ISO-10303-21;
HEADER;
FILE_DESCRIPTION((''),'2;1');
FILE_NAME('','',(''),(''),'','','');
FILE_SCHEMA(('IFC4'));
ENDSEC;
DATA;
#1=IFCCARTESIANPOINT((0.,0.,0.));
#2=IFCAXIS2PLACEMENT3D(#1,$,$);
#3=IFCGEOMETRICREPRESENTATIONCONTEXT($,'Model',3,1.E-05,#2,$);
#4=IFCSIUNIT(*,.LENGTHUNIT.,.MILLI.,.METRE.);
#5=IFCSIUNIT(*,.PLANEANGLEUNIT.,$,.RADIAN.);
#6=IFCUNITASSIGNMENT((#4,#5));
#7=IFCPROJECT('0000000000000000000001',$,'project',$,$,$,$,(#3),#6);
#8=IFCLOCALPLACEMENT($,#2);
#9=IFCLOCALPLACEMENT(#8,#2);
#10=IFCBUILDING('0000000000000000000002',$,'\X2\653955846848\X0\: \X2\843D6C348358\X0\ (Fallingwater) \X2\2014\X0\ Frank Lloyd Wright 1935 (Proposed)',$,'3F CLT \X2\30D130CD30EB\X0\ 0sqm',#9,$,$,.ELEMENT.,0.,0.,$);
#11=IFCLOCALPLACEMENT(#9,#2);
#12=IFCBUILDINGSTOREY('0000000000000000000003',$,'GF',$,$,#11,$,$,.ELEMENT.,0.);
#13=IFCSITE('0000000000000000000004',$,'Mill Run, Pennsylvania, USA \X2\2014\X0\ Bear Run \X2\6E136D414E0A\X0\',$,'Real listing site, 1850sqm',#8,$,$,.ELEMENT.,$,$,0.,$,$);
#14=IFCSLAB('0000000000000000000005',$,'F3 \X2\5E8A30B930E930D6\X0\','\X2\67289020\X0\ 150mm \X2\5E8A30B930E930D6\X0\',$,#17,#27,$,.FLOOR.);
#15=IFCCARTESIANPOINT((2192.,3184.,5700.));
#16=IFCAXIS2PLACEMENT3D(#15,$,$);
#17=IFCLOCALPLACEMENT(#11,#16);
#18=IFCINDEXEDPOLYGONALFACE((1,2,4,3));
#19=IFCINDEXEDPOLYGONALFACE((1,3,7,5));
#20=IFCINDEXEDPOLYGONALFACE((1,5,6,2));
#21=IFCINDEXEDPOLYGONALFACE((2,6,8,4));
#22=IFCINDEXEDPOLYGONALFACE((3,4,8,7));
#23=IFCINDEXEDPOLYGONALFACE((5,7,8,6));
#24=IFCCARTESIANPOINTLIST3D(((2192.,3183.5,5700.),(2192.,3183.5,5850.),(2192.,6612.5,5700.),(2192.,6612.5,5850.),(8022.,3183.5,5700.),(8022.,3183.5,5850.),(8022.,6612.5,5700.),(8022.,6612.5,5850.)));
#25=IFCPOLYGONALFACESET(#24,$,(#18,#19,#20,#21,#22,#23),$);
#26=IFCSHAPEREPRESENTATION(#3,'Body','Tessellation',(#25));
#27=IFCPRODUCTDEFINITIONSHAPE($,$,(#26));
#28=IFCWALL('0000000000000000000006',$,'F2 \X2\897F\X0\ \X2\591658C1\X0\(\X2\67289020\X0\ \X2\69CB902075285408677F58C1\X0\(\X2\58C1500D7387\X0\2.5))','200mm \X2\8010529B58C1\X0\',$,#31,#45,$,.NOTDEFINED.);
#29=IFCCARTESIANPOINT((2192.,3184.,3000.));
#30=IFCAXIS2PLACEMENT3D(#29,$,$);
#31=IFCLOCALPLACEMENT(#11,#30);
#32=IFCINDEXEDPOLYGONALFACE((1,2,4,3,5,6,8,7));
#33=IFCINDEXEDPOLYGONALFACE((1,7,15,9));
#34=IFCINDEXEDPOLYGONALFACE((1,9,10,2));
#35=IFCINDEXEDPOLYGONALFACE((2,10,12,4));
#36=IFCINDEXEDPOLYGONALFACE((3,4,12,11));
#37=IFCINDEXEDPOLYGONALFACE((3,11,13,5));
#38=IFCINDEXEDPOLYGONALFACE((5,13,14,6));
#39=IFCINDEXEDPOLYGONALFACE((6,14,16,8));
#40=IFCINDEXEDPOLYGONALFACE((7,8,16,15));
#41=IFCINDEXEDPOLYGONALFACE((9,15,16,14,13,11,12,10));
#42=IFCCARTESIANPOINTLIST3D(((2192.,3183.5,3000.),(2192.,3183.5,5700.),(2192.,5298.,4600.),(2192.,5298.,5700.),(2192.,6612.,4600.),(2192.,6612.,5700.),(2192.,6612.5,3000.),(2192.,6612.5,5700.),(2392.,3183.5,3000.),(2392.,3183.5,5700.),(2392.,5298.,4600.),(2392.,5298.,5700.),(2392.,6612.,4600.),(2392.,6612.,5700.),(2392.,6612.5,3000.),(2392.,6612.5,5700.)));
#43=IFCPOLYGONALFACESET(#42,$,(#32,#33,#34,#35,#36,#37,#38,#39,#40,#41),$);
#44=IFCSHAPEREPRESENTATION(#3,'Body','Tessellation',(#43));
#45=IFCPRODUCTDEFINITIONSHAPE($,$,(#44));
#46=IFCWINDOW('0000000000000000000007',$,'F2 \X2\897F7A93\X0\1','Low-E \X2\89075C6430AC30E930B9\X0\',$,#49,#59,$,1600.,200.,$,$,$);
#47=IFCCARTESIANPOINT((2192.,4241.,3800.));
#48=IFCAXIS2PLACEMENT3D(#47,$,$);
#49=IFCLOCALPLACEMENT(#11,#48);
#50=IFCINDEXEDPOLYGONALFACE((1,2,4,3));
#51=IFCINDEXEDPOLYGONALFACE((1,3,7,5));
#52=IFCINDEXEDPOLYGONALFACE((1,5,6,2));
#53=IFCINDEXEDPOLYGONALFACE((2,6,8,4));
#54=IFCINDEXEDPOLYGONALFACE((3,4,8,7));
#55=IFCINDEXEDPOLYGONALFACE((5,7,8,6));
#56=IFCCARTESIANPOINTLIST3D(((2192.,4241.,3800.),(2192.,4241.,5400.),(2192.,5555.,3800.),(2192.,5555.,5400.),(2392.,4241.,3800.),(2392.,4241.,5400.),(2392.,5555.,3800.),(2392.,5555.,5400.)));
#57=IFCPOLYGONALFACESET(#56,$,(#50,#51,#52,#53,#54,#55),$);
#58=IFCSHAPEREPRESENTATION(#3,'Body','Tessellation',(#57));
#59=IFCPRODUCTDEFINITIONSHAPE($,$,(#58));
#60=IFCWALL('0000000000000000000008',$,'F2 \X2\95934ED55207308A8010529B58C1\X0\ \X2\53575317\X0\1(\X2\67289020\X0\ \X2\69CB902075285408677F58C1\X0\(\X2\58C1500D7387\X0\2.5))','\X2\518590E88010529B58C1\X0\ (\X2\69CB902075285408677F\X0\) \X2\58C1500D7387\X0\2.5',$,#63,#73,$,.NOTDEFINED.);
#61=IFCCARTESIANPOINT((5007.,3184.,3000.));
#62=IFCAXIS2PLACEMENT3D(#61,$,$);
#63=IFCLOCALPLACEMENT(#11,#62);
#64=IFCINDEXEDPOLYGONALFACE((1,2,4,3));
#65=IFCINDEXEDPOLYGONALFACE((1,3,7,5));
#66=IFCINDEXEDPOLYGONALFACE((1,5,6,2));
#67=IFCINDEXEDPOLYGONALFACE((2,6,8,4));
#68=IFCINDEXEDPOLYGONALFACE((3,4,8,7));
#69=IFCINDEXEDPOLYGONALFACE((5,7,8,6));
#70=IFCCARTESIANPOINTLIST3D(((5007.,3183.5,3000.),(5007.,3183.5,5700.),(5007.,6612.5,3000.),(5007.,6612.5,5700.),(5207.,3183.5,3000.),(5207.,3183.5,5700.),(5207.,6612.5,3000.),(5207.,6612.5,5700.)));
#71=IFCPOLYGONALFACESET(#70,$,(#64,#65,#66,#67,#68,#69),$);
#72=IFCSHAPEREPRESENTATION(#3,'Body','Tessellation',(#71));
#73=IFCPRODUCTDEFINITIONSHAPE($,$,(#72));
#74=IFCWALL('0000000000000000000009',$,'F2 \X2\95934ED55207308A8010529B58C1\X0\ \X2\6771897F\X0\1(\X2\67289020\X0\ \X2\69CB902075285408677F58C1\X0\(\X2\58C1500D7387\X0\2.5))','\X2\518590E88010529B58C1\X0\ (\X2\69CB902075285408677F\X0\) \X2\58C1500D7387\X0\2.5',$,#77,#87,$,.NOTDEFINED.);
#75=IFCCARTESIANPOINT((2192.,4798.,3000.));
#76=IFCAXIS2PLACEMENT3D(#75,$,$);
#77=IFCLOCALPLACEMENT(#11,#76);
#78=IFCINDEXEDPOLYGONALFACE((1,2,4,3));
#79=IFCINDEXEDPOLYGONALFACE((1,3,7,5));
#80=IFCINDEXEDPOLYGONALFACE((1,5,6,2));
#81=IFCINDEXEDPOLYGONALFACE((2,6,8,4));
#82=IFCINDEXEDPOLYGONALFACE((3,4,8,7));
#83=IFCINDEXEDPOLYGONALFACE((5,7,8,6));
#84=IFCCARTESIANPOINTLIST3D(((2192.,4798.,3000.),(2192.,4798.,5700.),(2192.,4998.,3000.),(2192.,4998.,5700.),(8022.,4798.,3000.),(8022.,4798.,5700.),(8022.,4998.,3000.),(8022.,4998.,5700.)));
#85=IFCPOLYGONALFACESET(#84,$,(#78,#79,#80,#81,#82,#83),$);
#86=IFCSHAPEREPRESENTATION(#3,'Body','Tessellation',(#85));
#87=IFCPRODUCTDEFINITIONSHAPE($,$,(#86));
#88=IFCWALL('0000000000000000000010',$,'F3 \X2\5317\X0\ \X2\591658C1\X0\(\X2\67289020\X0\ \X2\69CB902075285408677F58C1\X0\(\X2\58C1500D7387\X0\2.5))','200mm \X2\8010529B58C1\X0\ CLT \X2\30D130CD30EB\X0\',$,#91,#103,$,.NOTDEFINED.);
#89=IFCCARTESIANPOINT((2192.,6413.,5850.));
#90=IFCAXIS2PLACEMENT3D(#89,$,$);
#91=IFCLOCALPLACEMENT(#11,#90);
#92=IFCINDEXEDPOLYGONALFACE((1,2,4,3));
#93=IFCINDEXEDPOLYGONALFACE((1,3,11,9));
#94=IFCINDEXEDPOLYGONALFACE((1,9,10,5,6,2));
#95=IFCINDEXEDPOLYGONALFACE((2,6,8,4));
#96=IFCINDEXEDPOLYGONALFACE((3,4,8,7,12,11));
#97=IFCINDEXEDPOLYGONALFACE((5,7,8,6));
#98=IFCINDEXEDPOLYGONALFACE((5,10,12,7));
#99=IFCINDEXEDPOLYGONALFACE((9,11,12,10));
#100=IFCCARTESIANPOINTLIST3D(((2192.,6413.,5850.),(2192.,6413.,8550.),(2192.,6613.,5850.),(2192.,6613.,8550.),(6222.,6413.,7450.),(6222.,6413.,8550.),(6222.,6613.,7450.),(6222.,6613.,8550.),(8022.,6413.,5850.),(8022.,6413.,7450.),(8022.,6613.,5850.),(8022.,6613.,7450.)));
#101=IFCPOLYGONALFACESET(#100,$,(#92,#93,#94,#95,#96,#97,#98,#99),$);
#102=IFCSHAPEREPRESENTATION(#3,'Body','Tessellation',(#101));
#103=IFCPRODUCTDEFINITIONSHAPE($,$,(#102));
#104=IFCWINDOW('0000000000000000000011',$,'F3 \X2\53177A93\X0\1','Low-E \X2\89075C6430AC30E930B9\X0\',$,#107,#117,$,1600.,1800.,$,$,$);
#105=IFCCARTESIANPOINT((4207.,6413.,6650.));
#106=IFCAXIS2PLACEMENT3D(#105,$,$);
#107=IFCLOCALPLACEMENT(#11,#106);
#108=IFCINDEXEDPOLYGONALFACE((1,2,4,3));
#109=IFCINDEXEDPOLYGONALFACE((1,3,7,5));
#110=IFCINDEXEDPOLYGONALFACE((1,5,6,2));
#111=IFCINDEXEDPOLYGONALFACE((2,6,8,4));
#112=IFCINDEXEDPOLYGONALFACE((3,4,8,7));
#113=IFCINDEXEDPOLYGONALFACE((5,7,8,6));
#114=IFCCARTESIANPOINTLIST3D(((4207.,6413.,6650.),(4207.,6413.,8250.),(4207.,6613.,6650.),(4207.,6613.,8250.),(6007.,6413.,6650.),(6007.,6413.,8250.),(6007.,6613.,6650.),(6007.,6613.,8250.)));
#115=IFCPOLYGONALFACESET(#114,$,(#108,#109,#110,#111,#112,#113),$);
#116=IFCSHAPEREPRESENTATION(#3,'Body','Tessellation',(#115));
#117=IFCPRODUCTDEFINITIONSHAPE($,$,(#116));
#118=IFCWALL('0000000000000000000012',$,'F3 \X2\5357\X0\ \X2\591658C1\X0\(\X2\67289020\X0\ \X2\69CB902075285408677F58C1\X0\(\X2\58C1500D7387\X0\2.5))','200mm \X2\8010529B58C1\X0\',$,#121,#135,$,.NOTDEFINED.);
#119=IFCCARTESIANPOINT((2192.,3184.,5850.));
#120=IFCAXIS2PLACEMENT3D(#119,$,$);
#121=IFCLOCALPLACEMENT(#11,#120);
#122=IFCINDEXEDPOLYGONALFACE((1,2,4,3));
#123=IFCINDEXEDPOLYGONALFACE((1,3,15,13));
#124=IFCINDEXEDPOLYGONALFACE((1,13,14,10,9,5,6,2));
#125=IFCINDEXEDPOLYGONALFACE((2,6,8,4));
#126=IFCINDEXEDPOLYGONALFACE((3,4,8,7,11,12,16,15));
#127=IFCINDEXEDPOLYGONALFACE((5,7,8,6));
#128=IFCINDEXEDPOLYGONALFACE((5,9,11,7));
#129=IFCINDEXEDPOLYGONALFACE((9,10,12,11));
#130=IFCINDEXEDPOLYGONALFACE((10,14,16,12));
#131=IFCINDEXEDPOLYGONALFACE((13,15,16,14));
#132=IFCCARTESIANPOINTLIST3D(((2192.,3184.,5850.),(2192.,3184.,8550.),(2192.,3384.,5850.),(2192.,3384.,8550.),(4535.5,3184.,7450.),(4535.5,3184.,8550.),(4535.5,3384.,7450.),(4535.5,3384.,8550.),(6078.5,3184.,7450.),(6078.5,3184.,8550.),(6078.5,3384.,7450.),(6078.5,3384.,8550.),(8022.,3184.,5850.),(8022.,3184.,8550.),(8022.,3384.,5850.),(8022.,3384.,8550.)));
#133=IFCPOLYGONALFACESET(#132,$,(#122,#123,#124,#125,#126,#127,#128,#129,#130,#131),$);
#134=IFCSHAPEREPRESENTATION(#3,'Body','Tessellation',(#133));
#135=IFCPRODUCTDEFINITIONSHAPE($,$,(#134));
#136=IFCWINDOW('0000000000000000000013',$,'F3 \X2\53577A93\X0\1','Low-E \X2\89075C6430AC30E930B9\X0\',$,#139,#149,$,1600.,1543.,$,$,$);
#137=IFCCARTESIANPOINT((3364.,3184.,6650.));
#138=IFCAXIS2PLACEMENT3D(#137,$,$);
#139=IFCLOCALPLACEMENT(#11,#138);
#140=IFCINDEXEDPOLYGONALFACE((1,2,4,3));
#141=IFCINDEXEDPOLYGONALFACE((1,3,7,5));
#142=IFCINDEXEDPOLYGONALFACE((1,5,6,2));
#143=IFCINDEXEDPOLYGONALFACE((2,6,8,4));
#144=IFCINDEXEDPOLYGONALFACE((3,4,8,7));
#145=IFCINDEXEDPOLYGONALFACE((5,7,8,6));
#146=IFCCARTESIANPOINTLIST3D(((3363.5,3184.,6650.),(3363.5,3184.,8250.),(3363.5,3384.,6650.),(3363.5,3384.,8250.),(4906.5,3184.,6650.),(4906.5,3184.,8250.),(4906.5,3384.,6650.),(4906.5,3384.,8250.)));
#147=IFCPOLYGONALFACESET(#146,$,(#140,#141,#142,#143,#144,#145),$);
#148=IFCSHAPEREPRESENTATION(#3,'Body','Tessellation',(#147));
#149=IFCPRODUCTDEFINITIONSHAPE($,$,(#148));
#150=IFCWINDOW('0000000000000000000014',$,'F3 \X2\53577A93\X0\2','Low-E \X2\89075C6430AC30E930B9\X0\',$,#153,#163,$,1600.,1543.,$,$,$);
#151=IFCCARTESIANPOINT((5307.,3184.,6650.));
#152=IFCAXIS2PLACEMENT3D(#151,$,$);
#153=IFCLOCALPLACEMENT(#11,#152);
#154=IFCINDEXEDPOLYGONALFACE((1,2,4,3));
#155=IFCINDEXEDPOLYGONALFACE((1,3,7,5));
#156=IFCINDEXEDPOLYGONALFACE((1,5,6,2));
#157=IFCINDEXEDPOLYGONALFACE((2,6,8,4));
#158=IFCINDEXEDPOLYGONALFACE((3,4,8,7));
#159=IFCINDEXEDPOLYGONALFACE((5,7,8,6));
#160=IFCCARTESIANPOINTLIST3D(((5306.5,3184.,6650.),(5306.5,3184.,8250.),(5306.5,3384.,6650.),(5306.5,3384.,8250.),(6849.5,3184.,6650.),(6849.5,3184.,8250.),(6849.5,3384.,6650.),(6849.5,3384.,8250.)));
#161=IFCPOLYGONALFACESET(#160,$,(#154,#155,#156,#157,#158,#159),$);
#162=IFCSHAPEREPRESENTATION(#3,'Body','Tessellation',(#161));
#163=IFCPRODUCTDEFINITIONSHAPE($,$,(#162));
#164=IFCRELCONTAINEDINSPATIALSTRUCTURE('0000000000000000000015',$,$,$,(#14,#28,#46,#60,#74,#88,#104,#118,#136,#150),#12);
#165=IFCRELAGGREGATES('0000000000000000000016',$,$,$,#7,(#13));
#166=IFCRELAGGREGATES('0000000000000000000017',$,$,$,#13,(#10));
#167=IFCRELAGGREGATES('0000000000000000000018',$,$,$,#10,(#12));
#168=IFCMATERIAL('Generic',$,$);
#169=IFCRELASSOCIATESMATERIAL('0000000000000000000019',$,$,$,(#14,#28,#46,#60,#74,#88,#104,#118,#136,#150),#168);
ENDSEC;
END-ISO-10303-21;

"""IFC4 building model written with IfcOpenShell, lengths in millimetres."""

from ifc_helpers import new_model, si_unit, frame, frame_2d, origin, place, context, project, spatial, rectangle, extrude, material, element, fill, save


model = new_model("IFC4")

# Units and contexts
model_context = context("Model", 3, precision=1e-05, world=origin())
ifc_project = project(units=[si_unit("LENGTHUNIT", "METRE", prefix="MILLI"), si_unit("PLANEANGLEUNIT", "RADIAN")], contexts=[model_context])

# Site, building, storey
site_placement = place(None, origin())
site = spatial("IfcSite", under=ifc_project, at=site_placement, Name="Mill Run, Pennsylvania, USA — Bear Run 渓流上", ObjectType="Real listing site, 1850sqm", CompositionType="ELEMENT", RefElevation=0.0)
building_placement = place(site_placement, origin())
building = spatial("IfcBuilding", under=site, at=building_placement, Name="改善案: 落水荘 (Fallingwater) — Frank Lloyd Wright 1935 (Proposed)", ObjectType="3F CLT パネル 0sqm", CompositionType="ELEMENT", ElevationOfRefHeight=0.0, ElevationOfTerrain=0.0)
storey_placement = place(building_placement, origin())
storey = spatial("IfcBuildingStorey", under=building, at=storey_placement, Name="GF", CompositionType="ELEMENT", Elevation=0.0)

# Slab
ifc_material_1 = material(Name="Generic")
slab_placement = place(storey_placement, frame((2192.0, 3184.0, 5700.0)))
element("IfcSlab", 1, at=slab_placement, inside=storey, material=ifc_material_1, Name="F3 床スラブ", Description="木造 150mm 床スラブ", PredefinedType="FLOOR", context=model_context, shape_type="SweptSolid", body=[
    extrude(rectangle(XDim=5830.0, YDim=3429.0, at=frame_2d((2915.0, 1714.0))), frame((2192.0, 3184.0, 5700.0)), (0.0, 0.0, 1.0), 150.0),
])

# Wall, opening, window
wall_1_placement = place(storey_placement, frame((2192.0, 3184.0, 3000.0)))
wall_1 = element("IfcWall", 2, at=wall_1_placement, inside=storey, material=ifc_material_1, Name="F2 西 外壁(木造 構造用合板壁(壁倍率2.5))", Description="200mm 耐力壁", PredefinedType="NOTDEFINED", context=model_context, shape_type="SweptSolid", body=[
    extrude(rectangle(XDim=200.0, YDim=3429.0, at=frame_2d((100.0, 1714.0))), frame((2192.0, 3184.0, 3000.0)), (0.0, 0.0, 1.0), 2700.0),
])
opening_1_placement = place(storey_placement, frame((2192.0, 4241.0, 3800.0)))
opening_1 = element("IfcOpeningElement", 3, at=opening_1_placement, cuts=wall_1, PredefinedType="NOTDEFINED", context=model_context, shape_type="SweptSolid", body=[
    extrude(rectangle(XDim=200.0, YDim=1314.0, at=frame_2d((100.0, 657.0))), frame((2192.0, 4241.0, 3800.0)), (0.0, 0.0, 1.0), 1600.0),
])
window_1_placement = place(storey_placement, frame((2192.0, 4241.0, 3800.0)))
window_1 = element("IfcWindow", 4, at=window_1_placement, inside=storey, material=ifc_material_1, Name="F2 西窓1", Description="Low-E 複層ガラス", OverallHeight=1600.0, OverallWidth=200.0, context=model_context, shape_type="SweptSolid", body=[
    extrude(rectangle(XDim=200.0, YDim=1314.0, at=frame_2d((100.0, 657.0))), frame((2192.0, 4241.0, 3800.0)), (0.0, 0.0, 1.0), 1600.0),
])
fill(opening_1, window_1)

# Walls
wall_2_placement = place(storey_placement, frame((5007.0, 3184.0, 3000.0)))
element("IfcWall", 5, at=wall_2_placement, inside=storey, material=ifc_material_1, Name="F2 間仕切り耐力壁 南北1(木造 構造用合板壁(壁倍率2.5))", Description="内部耐力壁 (構造用合板) 壁倍率2.5", PredefinedType="NOTDEFINED", context=model_context, shape_type="SweptSolid", body=[
    extrude(rectangle(XDim=200.0, YDim=3429.0, at=frame_2d((100.0, 1714.0))), frame((5007.0, 3184.0, 3000.0)), (0.0, 0.0, 1.0), 2700.0),
])
wall_3_placement = place(storey_placement, frame((2192.0, 4798.0, 3000.0)))
element("IfcWall", 6, at=wall_3_placement, inside=storey, material=ifc_material_1, Name="F2 間仕切り耐力壁 東西1(木造 構造用合板壁(壁倍率2.5))", Description="内部耐力壁 (構造用合板) 壁倍率2.5", PredefinedType="NOTDEFINED", context=model_context, shape_type="SweptSolid", body=[
    extrude(rectangle(XDim=5830.0, YDim=200.0, at=frame_2d((2915.0, 100.0))), frame((2192.0, 4798.0, 3000.0)), (0.0, 0.0, 1.0), 2700.0),
])

# Wall, opening, window
wall_4_placement = place(storey_placement, frame((2192.0, 6413.0, 5850.0)))
wall_4 = element("IfcWall", 7, at=wall_4_placement, inside=storey, material=ifc_material_1, Name="F3 北 外壁(木造 構造用合板壁(壁倍率2.5))", Description="200mm 耐力壁 CLT パネル", PredefinedType="NOTDEFINED", context=model_context, shape_type="SweptSolid", body=[
    extrude(rectangle(XDim=5830.0, YDim=200.0, at=frame_2d((2915.0, 100.0))), frame((2192.0, 6413.0, 5850.0)), (0.0, 0.0, 1.0), 2700.0),
])
opening_2_placement = place(storey_placement, frame((4207.0, 6413.0, 6650.0)))
opening_2 = element("IfcOpeningElement", 8, at=opening_2_placement, cuts=wall_4, PredefinedType="NOTDEFINED", context=model_context, shape_type="SweptSolid", body=[
    extrude(rectangle(XDim=1800.0, YDim=200.0, at=frame_2d((900.0, 100.0))), frame((4207.0, 6413.0, 6650.0)), (0.0, 0.0, 1.0), 1600.0),
])
window_2_placement = place(storey_placement, frame((4207.0, 6413.0, 6650.0)))
window_2 = element("IfcWindow", 9, at=window_2_placement, inside=storey, material=ifc_material_1, Name="F3 北窓1", Description="Low-E 複層ガラス", OverallHeight=1600.0, OverallWidth=1800.0, context=model_context, shape_type="SweptSolid", body=[
    extrude(rectangle(XDim=1800.0, YDim=200.0, at=frame_2d((900.0, 100.0))), frame((4207.0, 6413.0, 6650.0)), (0.0, 0.0, 1.0), 1600.0),
])
fill(opening_2, window_2)

# Wall, openings, windows
wall_5_placement = place(storey_placement, frame((2192.0, 3184.0, 5850.0)))
wall_5 = element("IfcWall", 10, at=wall_5_placement, inside=storey, material=ifc_material_1, Name="F3 南 外壁(木造 構造用合板壁(壁倍率2.5))", Description="200mm 耐力壁", PredefinedType="NOTDEFINED", context=model_context, shape_type="SweptSolid", body=[
    extrude(rectangle(XDim=5830.0, YDim=200.0, at=frame_2d((2915.0, 100.0))), frame((2192.0, 3184.0, 5850.0)), (0.0, 0.0, 1.0), 2700.0),
])
opening_3_placement = place(storey_placement, frame((3364.0, 3184.0, 6650.0)))
opening_3 = element("IfcOpeningElement", 11, at=opening_3_placement, cuts=wall_5, PredefinedType="NOTDEFINED", context=model_context, shape_type="SweptSolid", body=[
    extrude(rectangle(XDim=1543.0, YDim=200.0, at=frame_2d((771.0, 100.0))), frame((3364.0, 3184.0, 6650.0)), (0.0, 0.0, 1.0), 1600.0),
])
opening_4_placement = place(storey_placement, frame((5307.0, 3184.0, 6650.0)))
opening_4 = element("IfcOpeningElement", 12, at=opening_4_placement, cuts=wall_5, PredefinedType="NOTDEFINED", context=model_context, shape_type="SweptSolid", body=[
    extrude(rectangle(XDim=1543.0, YDim=200.0, at=frame_2d((771.0, 100.0))), frame((5307.0, 3184.0, 6650.0)), (0.0, 0.0, 1.0), 1600.0),
])
window_3_placement = place(storey_placement, frame((3364.0, 3184.0, 6650.0)))
window_3 = element("IfcWindow", 13, at=window_3_placement, inside=storey, material=ifc_material_1, Name="F3 南窓1", Description="Low-E 複層ガラス", OverallHeight=1600.0, OverallWidth=1543.0, context=model_context, shape_type="SweptSolid", body=[
    extrude(rectangle(XDim=1543.0, YDim=200.0, at=frame_2d((771.0, 100.0))), frame((3364.0, 3184.0, 6650.0)), (0.0, 0.0, 1.0), 1600.0),
])
fill(opening_3, window_3)
window_4_placement = place(storey_placement, frame((5307.0, 3184.0, 6650.0)))
window_4 = element("IfcWindow", 14, at=window_4_placement, inside=storey, material=ifc_material_1, Name="F3 南窓2", Description="Low-E 複層ガラス", OverallHeight=1600.0, OverallWidth=1543.0, context=model_context, shape_type="SweptSolid", body=[
    extrude(rectangle(XDim=1543.0, YDim=200.0, at=frame_2d((771.0, 100.0))), frame((5307.0, 3184.0, 6650.0)), (0.0, 0.0, 1.0), 1600.0),
])
fill(opening_4, window_4)

save(model, "model.ifc")
